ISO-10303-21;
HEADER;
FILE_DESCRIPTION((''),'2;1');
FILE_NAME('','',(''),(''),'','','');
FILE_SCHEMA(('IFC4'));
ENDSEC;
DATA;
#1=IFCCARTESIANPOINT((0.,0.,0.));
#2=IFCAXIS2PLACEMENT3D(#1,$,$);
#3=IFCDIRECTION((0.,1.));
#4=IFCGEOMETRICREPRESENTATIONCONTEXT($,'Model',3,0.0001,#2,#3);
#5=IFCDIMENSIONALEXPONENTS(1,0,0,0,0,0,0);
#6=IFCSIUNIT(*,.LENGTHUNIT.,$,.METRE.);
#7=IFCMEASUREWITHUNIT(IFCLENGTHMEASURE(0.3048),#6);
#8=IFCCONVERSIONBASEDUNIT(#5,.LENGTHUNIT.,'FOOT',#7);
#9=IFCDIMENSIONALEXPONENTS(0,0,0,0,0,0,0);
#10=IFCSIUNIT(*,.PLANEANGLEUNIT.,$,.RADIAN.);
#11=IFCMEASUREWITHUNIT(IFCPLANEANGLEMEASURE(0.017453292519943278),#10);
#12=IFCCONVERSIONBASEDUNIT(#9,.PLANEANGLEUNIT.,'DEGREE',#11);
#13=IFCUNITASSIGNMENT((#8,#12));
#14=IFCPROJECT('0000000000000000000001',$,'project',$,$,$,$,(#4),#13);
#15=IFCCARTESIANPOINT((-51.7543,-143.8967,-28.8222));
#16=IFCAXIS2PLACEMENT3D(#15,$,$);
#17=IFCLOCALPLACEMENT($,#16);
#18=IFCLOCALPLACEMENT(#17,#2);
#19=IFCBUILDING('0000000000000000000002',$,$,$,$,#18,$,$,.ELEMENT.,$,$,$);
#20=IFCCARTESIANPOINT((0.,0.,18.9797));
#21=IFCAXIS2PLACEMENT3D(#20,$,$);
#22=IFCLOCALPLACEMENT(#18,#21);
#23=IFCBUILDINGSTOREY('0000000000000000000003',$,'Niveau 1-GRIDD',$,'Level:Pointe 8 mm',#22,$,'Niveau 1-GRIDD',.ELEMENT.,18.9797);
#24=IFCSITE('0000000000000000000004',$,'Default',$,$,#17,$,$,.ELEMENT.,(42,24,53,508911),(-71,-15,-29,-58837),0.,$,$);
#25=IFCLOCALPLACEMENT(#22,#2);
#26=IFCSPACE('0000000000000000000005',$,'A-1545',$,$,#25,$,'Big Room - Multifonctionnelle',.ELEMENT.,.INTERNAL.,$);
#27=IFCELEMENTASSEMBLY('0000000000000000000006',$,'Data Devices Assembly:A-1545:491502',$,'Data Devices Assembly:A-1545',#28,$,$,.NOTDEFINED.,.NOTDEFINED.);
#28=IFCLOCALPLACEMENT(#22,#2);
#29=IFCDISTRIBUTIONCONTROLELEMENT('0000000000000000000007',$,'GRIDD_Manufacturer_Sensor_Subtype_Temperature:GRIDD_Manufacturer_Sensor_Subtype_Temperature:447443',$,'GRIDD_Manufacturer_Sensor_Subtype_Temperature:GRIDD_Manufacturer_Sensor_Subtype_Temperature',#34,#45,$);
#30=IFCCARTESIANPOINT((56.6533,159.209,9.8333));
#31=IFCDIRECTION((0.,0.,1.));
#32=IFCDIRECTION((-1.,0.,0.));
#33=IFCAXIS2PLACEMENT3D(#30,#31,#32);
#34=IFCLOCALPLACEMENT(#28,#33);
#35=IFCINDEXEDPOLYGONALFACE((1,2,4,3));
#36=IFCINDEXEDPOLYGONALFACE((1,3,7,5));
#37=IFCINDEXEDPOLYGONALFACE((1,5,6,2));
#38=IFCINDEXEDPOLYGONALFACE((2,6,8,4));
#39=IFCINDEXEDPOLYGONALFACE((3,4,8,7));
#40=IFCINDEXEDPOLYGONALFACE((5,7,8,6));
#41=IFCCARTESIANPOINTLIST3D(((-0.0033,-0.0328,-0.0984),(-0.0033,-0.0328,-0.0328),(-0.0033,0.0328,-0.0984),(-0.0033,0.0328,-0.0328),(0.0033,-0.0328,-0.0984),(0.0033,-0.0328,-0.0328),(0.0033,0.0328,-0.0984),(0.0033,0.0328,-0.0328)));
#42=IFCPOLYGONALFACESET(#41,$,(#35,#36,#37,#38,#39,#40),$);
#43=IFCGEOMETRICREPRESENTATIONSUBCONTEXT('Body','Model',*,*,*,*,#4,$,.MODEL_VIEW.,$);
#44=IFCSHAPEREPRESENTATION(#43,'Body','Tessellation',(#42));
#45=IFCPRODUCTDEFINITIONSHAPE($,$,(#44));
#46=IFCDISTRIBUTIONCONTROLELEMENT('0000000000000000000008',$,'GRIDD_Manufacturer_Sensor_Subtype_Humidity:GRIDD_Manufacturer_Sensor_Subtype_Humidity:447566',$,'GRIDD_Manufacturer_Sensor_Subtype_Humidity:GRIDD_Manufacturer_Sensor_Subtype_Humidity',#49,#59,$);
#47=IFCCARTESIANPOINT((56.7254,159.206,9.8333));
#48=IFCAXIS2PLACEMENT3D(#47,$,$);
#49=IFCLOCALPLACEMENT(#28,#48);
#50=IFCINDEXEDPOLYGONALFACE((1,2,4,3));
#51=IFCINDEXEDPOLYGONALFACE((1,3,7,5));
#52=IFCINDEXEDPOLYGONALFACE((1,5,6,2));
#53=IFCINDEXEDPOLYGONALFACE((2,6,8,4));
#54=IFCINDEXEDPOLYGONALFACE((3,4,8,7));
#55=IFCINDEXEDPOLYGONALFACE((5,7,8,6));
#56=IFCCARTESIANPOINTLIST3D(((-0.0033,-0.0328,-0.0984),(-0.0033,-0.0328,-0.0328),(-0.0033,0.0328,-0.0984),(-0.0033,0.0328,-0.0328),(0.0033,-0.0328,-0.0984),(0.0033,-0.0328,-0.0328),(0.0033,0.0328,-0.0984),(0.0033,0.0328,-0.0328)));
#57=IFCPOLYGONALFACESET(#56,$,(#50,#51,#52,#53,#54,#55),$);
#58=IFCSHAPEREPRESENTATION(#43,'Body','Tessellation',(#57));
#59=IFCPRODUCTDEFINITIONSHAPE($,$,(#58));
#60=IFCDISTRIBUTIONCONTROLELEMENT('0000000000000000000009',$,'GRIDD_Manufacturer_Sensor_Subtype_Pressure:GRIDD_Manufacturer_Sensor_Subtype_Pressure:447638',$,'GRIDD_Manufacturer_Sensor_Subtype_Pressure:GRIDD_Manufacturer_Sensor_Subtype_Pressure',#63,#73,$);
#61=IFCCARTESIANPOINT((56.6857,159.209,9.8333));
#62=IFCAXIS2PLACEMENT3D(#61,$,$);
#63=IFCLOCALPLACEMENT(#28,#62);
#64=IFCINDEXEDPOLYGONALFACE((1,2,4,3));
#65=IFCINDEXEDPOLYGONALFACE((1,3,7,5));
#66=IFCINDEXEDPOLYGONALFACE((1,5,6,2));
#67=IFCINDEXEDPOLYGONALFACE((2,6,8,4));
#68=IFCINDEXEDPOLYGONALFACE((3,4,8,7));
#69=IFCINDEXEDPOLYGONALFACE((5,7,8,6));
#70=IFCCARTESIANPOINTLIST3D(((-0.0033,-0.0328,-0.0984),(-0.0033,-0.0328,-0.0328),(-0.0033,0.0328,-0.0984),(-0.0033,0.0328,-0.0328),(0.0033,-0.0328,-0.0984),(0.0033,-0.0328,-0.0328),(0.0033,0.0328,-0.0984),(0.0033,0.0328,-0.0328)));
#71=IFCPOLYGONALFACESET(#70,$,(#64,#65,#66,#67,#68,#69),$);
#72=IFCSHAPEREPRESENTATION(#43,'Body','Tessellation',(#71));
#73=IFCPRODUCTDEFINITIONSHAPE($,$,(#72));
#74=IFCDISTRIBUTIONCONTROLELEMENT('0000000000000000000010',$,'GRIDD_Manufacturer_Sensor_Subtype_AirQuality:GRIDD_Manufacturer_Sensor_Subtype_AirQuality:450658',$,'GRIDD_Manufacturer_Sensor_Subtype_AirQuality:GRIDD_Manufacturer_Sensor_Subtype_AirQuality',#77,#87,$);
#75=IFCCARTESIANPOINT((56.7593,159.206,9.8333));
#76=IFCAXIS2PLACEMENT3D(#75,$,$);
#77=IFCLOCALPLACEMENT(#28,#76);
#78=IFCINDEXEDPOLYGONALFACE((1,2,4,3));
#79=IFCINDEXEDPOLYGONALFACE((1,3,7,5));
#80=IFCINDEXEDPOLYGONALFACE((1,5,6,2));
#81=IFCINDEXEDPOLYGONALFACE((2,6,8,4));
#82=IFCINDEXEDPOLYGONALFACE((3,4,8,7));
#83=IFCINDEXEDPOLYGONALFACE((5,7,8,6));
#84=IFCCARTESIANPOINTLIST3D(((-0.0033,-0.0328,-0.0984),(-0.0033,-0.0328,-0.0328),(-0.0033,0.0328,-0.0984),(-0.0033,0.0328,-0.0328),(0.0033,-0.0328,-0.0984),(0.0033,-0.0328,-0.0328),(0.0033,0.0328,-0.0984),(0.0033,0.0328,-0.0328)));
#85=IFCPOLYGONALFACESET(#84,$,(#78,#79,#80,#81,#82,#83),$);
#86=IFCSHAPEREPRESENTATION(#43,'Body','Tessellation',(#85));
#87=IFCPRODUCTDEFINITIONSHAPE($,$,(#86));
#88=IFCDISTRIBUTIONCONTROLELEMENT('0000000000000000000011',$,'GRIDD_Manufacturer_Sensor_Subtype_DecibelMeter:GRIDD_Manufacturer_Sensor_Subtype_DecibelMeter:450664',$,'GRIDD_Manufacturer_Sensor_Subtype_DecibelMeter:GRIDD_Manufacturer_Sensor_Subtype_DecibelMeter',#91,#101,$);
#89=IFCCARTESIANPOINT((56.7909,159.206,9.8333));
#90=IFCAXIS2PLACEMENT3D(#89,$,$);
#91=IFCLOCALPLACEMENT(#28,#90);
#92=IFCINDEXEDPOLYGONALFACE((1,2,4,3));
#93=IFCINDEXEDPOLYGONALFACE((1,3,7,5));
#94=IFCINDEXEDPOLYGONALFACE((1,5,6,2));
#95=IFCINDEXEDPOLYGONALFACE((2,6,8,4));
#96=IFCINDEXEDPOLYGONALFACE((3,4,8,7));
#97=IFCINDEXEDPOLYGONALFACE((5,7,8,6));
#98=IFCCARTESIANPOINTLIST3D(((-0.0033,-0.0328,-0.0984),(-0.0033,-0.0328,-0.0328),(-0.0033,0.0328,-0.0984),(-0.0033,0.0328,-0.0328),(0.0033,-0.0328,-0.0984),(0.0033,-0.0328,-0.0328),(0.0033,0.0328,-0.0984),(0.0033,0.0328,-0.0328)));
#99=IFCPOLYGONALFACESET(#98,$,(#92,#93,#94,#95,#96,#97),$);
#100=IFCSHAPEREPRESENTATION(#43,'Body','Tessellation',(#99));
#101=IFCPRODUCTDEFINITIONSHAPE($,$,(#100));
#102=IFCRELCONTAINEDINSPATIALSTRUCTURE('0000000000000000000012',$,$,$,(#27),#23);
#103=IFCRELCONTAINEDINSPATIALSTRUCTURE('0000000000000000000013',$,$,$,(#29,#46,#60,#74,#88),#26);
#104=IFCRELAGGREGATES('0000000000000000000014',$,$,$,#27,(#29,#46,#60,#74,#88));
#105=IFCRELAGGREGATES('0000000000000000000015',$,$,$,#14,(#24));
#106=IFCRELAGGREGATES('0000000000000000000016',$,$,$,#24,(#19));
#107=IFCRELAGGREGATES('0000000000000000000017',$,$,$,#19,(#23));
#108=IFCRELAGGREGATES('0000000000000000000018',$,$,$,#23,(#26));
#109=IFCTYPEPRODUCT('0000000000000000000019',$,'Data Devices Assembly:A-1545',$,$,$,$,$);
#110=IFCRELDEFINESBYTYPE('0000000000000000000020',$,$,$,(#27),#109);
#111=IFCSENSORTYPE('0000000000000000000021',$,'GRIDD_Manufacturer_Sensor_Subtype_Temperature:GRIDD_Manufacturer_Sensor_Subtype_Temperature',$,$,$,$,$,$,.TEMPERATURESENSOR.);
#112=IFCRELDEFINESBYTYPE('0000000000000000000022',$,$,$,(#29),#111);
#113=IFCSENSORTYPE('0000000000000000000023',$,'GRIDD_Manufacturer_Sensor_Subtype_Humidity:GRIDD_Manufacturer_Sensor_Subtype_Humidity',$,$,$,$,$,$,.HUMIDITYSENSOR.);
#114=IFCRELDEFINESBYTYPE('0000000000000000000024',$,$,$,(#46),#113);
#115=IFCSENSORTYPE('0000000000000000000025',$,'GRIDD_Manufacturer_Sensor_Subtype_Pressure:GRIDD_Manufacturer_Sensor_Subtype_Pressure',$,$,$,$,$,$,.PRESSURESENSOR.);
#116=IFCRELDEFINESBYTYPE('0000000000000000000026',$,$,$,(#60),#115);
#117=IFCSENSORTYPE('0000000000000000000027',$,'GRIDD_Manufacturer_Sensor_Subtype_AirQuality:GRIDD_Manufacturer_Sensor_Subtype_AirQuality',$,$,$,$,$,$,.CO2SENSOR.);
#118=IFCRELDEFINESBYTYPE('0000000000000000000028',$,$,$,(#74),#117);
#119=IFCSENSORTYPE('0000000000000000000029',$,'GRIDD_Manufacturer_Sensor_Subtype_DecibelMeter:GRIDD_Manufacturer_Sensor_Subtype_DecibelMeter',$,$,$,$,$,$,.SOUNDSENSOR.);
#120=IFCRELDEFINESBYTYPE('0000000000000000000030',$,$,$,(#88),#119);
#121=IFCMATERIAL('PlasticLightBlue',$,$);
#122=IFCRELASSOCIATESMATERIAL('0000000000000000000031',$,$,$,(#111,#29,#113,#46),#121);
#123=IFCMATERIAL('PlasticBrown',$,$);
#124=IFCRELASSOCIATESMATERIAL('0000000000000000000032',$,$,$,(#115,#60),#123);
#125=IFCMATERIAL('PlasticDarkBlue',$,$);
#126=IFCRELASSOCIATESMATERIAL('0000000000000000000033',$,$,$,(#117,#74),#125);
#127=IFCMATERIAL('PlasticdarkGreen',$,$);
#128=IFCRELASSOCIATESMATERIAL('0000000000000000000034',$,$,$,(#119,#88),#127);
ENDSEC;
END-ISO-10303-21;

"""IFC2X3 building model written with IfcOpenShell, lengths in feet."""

from ifc_helpers import new_model, entity, si_unit, converted_unit, direction, frame, origin, origin_2d_with_axis, place, context, subcontext, project, spatial, rectangle, extrude, source, transform, mapped, material, type_object, type_shapes, element, aggregate, save


model = new_model("IFC2X3")

# Units and contexts
model_context = context("Model", 3, precision=0.0001, world=origin(), true_north=direction((0.0, 1.0)))
body_context = subcontext(model_context, "Body", "Model", "MODEL_VIEW")
ifc_project = project(units=[converted_unit("LENGTHUNIT", "FOOT", entity("IfcLengthMeasure", 0.3048), si_unit("LENGTHUNIT", "METRE"), dimensions=[1, 0, 0, 0, 0, 0, 0]), converted_unit("PLANEANGLEUNIT", "DEGREE", entity("IfcPlaneAngleMeasure", 0.017453292519943278), si_unit("PLANEANGLEUNIT", "RADIAN"), dimensions=[0, 0, 0, 0, 0, 0, 0])], contexts=[model_context])

# Site, building, storey
site_placement = place(None, frame((-51.7543, -143.8967, -28.8222)))
site = spatial("IfcSite", under=ifc_project, at=site_placement, Name="Default", CompositionType="ELEMENT", RefLatitude=(42, 24, 53, 508911), RefLongitude=(-71, -15, -29, -58837), RefElevation=0.0)
building_placement = place(site_placement, origin())
building = spatial("IfcBuilding", under=site, at=building_placement, CompositionType="ELEMENT")
storey_placement = place(building_placement, frame((0.0, 0.0, 18.9797)))
storey = spatial("IfcBuildingStorey", under=building, at=storey_placement, Name="Niveau 1-GRIDD", ObjectType="Level:Pointe 8 mm", LongName="Niveau 1-GRIDD", CompositionType="ELEMENT", Elevation=18.9797)

# Shared definitions
space_placement = place(storey_placement, origin())
space = spatial("IfcSpace", under=storey, at=space_placement, Name="A-1545", LongName="Big Room - Multifonctionnelle", CompositionType="ELEMENT", InteriorOrExteriorSpace="INTERNAL")

# Element assembly, distribution control elements
type_product = type_object("IfcTypeProduct", Name="Data Devices Assembly:A-1545")
assembly_placement = place(storey_placement, origin())
assembly = element("IfcElementAssembly", 1, at=assembly_placement, inside=storey, type_object=type_product, Name="Data Devices Assembly:A-1545:491502", ObjectType="Data Devices Assembly:A-1545", AssemblyPlace="NOTDEFINED", PredefinedType="NOTDEFINED")
ifc_material_1 = material(Name="PlasticLightBlue")
sensor_type_1 = type_object("IfcSensorType", Name="GRIDD_Manufacturer_Sensor_Subtype_Temperature:GRIDD_Manufacturer_Sensor_Subtype_Temperature", PredefinedType="TEMPERATURESENSOR", material=ifc_material_1)
shared_shape_1 = source(origin(), body_context, "Body", "SweptSolid", [
    extrude(rectangle(XDim=0.0066, YDim=0.0656, at=origin_2d_with_axis()), frame((0.0, 0.0, -0.0984), z_axis=(0.0, 0.0, 1.0), x_axis=(-1.0, 0.0, 0.0)), (0.0, 0.0, 1.0), 0.0656),
])
type_shapes(sensor_type_1, [shared_shape_1])
distribution_control_element_1_placement = place(assembly_placement, frame((56.6533, 159.209, 9.8333), z_axis=(0.0, 0.0, 1.0), x_axis=(-1.0, 0.0, 0.0)))
distribution_control_element_1 = element("IfcDistributionControlElement", 2, at=distribution_control_element_1_placement, inside=space, type_object=sensor_type_1, material=ifc_material_1, Name="GRIDD_Manufacturer_Sensor_Subtype_Temperature:GRIDD_Manufacturer_Sensor_Subtype_Temperature:447443", ObjectType="GRIDD_Manufacturer_Sensor_Subtype_Temperature:GRIDD_Manufacturer_Sensor_Subtype_Temperature", context=body_context, shape_type="MappedRepresentation", body=[
    mapped(shared_shape_1, transform((0.0, 0.0, 0.0), scale=1.0)),
])
sensor_type_2 = type_object("IfcSensorType", Name="GRIDD_Manufacturer_Sensor_Subtype_Humidity:GRIDD_Manufacturer_Sensor_Subtype_Humidity", PredefinedType="HUMIDITYSENSOR", material=ifc_material_1)
shared_shape_2 = source(origin(), body_context, "Body", "SweptSolid", [
    extrude(rectangle(XDim=0.0066, YDim=0.0656, at=origin_2d_with_axis()), frame((0.0, 0.0, -0.0984), z_axis=(0.0, 0.0, 1.0), x_axis=(-1.0, 0.0, 0.0)), (0.0, 0.0, 1.0), 0.0656),
])
type_shapes(sensor_type_2, [shared_shape_2])
distribution_control_element_2_placement = place(assembly_placement, frame((56.7254, 159.206, 9.8333)))
distribution_control_element_2 = element("IfcDistributionControlElement", 3, at=distribution_control_element_2_placement, inside=space, type_object=sensor_type_2, material=ifc_material_1, Name="GRIDD_Manufacturer_Sensor_Subtype_Humidity:GRIDD_Manufacturer_Sensor_Subtype_Humidity:447566", ObjectType="GRIDD_Manufacturer_Sensor_Subtype_Humidity:GRIDD_Manufacturer_Sensor_Subtype_Humidity", context=body_context, shape_type="MappedRepresentation", body=[
    mapped(shared_shape_2, transform((0.0, 0.0, 0.0), scale=1.0)),
])
ifc_material_2 = material(Name="PlasticBrown")
sensor_type_3 = type_object("IfcSensorType", Name="GRIDD_Manufacturer_Sensor_Subtype_Pressure:GRIDD_Manufacturer_Sensor_Subtype_Pressure", PredefinedType="PRESSURESENSOR", material=ifc_material_2)
shared_shape_3 = source(origin(), body_context, "Body", "SweptSolid", [
    extrude(rectangle(XDim=0.0066, YDim=0.0656, at=origin_2d_with_axis()), frame((0.0, 0.0, -0.0984), z_axis=(0.0, 0.0, 1.0), x_axis=(-1.0, 0.0, 0.0)), (0.0, 0.0, 1.0), 0.0656),
])
type_shapes(sensor_type_3, [shared_shape_3])
distribution_control_element_3_placement = place(assembly_placement, frame((56.6857, 159.209, 9.8333)))
distribution_control_element_3 = element("IfcDistributionControlElement", 4, at=distribution_control_element_3_placement, inside=space, type_object=sensor_type_3, material=ifc_material_2, Name="GRIDD_Manufacturer_Sensor_Subtype_Pressure:GRIDD_Manufacturer_Sensor_Subtype_Pressure:447638", ObjectType="GRIDD_Manufacturer_Sensor_Subtype_Pressure:GRIDD_Manufacturer_Sensor_Subtype_Pressure", context=body_context, shape_type="MappedRepresentation", body=[
    mapped(shared_shape_3, transform((0.0, 0.0, 0.0), scale=1.0)),
])
ifc_material_3 = material(Name="PlasticDarkBlue")
sensor_type_4 = type_object("IfcSensorType", Name="GRIDD_Manufacturer_Sensor_Subtype_AirQuality:GRIDD_Manufacturer_Sensor_Subtype_AirQuality", PredefinedType="CO2SENSOR", material=ifc_material_3)
shared_shape_4 = source(origin(), body_context, "Body", "SweptSolid", [
    extrude(rectangle(XDim=0.0066, YDim=0.0656, at=origin_2d_with_axis()), frame((0.0, 0.0, -0.0984), z_axis=(0.0, 0.0, 1.0), x_axis=(-1.0, 0.0, 0.0)), (0.0, 0.0, 1.0), 0.0656),
])
type_shapes(sensor_type_4, [shared_shape_4])
distribution_control_element_4_placement = place(assembly_placement, frame((56.7593, 159.206, 9.8333)))
distribution_control_element_4 = element("IfcDistributionControlElement", 5, at=distribution_control_element_4_placement, inside=space, type_object=sensor_type_4, material=ifc_material_3, Name="GRIDD_Manufacturer_Sensor_Subtype_AirQuality:GRIDD_Manufacturer_Sensor_Subtype_AirQuality:450658", ObjectType="GRIDD_Manufacturer_Sensor_Subtype_AirQuality:GRIDD_Manufacturer_Sensor_Subtype_AirQuality", context=body_context, shape_type="MappedRepresentation", body=[
    mapped(shared_shape_4, transform((0.0, 0.0, 0.0), scale=1.0)),
])
ifc_material_4 = material(Name="PlasticdarkGreen")
sensor_type_5 = type_object("IfcSensorType", Name="GRIDD_Manufacturer_Sensor_Subtype_DecibelMeter:GRIDD_Manufacturer_Sensor_Subtype_DecibelMeter", PredefinedType="SOUNDSENSOR", material=ifc_material_4)
shared_shape_5 = source(origin(), body_context, "Body", "SweptSolid", [
    extrude(rectangle(XDim=0.0066, YDim=0.0656, at=origin_2d_with_axis()), frame((0.0, 0.0, -0.0984), z_axis=(0.0, 0.0, 1.0), x_axis=(-1.0, 0.0, 0.0)), (0.0, 0.0, 1.0), 0.0656),
])
type_shapes(sensor_type_5, [shared_shape_5])
distribution_control_element_5_placement = place(assembly_placement, frame((56.7909, 159.206, 9.8333)))
distribution_control_element_5 = element("IfcDistributionControlElement", 6, at=distribution_control_element_5_placement, inside=space, type_object=sensor_type_5, material=ifc_material_4, Name="GRIDD_Manufacturer_Sensor_Subtype_DecibelMeter:GRIDD_Manufacturer_Sensor_Subtype_DecibelMeter:450664", ObjectType="GRIDD_Manufacturer_Sensor_Subtype_DecibelMeter:GRIDD_Manufacturer_Sensor_Subtype_DecibelMeter", context=body_context, shape_type="MappedRepresentation", body=[
    mapped(shared_shape_5, transform((0.0, 0.0, 0.0), scale=1.0)),
])
aggregate(assembly, [distribution_control_element_1, distribution_control_element_2, distribution_control_element_3, distribution_control_element_4, distribution_control_element_5])

save(model, "model.ifc")
